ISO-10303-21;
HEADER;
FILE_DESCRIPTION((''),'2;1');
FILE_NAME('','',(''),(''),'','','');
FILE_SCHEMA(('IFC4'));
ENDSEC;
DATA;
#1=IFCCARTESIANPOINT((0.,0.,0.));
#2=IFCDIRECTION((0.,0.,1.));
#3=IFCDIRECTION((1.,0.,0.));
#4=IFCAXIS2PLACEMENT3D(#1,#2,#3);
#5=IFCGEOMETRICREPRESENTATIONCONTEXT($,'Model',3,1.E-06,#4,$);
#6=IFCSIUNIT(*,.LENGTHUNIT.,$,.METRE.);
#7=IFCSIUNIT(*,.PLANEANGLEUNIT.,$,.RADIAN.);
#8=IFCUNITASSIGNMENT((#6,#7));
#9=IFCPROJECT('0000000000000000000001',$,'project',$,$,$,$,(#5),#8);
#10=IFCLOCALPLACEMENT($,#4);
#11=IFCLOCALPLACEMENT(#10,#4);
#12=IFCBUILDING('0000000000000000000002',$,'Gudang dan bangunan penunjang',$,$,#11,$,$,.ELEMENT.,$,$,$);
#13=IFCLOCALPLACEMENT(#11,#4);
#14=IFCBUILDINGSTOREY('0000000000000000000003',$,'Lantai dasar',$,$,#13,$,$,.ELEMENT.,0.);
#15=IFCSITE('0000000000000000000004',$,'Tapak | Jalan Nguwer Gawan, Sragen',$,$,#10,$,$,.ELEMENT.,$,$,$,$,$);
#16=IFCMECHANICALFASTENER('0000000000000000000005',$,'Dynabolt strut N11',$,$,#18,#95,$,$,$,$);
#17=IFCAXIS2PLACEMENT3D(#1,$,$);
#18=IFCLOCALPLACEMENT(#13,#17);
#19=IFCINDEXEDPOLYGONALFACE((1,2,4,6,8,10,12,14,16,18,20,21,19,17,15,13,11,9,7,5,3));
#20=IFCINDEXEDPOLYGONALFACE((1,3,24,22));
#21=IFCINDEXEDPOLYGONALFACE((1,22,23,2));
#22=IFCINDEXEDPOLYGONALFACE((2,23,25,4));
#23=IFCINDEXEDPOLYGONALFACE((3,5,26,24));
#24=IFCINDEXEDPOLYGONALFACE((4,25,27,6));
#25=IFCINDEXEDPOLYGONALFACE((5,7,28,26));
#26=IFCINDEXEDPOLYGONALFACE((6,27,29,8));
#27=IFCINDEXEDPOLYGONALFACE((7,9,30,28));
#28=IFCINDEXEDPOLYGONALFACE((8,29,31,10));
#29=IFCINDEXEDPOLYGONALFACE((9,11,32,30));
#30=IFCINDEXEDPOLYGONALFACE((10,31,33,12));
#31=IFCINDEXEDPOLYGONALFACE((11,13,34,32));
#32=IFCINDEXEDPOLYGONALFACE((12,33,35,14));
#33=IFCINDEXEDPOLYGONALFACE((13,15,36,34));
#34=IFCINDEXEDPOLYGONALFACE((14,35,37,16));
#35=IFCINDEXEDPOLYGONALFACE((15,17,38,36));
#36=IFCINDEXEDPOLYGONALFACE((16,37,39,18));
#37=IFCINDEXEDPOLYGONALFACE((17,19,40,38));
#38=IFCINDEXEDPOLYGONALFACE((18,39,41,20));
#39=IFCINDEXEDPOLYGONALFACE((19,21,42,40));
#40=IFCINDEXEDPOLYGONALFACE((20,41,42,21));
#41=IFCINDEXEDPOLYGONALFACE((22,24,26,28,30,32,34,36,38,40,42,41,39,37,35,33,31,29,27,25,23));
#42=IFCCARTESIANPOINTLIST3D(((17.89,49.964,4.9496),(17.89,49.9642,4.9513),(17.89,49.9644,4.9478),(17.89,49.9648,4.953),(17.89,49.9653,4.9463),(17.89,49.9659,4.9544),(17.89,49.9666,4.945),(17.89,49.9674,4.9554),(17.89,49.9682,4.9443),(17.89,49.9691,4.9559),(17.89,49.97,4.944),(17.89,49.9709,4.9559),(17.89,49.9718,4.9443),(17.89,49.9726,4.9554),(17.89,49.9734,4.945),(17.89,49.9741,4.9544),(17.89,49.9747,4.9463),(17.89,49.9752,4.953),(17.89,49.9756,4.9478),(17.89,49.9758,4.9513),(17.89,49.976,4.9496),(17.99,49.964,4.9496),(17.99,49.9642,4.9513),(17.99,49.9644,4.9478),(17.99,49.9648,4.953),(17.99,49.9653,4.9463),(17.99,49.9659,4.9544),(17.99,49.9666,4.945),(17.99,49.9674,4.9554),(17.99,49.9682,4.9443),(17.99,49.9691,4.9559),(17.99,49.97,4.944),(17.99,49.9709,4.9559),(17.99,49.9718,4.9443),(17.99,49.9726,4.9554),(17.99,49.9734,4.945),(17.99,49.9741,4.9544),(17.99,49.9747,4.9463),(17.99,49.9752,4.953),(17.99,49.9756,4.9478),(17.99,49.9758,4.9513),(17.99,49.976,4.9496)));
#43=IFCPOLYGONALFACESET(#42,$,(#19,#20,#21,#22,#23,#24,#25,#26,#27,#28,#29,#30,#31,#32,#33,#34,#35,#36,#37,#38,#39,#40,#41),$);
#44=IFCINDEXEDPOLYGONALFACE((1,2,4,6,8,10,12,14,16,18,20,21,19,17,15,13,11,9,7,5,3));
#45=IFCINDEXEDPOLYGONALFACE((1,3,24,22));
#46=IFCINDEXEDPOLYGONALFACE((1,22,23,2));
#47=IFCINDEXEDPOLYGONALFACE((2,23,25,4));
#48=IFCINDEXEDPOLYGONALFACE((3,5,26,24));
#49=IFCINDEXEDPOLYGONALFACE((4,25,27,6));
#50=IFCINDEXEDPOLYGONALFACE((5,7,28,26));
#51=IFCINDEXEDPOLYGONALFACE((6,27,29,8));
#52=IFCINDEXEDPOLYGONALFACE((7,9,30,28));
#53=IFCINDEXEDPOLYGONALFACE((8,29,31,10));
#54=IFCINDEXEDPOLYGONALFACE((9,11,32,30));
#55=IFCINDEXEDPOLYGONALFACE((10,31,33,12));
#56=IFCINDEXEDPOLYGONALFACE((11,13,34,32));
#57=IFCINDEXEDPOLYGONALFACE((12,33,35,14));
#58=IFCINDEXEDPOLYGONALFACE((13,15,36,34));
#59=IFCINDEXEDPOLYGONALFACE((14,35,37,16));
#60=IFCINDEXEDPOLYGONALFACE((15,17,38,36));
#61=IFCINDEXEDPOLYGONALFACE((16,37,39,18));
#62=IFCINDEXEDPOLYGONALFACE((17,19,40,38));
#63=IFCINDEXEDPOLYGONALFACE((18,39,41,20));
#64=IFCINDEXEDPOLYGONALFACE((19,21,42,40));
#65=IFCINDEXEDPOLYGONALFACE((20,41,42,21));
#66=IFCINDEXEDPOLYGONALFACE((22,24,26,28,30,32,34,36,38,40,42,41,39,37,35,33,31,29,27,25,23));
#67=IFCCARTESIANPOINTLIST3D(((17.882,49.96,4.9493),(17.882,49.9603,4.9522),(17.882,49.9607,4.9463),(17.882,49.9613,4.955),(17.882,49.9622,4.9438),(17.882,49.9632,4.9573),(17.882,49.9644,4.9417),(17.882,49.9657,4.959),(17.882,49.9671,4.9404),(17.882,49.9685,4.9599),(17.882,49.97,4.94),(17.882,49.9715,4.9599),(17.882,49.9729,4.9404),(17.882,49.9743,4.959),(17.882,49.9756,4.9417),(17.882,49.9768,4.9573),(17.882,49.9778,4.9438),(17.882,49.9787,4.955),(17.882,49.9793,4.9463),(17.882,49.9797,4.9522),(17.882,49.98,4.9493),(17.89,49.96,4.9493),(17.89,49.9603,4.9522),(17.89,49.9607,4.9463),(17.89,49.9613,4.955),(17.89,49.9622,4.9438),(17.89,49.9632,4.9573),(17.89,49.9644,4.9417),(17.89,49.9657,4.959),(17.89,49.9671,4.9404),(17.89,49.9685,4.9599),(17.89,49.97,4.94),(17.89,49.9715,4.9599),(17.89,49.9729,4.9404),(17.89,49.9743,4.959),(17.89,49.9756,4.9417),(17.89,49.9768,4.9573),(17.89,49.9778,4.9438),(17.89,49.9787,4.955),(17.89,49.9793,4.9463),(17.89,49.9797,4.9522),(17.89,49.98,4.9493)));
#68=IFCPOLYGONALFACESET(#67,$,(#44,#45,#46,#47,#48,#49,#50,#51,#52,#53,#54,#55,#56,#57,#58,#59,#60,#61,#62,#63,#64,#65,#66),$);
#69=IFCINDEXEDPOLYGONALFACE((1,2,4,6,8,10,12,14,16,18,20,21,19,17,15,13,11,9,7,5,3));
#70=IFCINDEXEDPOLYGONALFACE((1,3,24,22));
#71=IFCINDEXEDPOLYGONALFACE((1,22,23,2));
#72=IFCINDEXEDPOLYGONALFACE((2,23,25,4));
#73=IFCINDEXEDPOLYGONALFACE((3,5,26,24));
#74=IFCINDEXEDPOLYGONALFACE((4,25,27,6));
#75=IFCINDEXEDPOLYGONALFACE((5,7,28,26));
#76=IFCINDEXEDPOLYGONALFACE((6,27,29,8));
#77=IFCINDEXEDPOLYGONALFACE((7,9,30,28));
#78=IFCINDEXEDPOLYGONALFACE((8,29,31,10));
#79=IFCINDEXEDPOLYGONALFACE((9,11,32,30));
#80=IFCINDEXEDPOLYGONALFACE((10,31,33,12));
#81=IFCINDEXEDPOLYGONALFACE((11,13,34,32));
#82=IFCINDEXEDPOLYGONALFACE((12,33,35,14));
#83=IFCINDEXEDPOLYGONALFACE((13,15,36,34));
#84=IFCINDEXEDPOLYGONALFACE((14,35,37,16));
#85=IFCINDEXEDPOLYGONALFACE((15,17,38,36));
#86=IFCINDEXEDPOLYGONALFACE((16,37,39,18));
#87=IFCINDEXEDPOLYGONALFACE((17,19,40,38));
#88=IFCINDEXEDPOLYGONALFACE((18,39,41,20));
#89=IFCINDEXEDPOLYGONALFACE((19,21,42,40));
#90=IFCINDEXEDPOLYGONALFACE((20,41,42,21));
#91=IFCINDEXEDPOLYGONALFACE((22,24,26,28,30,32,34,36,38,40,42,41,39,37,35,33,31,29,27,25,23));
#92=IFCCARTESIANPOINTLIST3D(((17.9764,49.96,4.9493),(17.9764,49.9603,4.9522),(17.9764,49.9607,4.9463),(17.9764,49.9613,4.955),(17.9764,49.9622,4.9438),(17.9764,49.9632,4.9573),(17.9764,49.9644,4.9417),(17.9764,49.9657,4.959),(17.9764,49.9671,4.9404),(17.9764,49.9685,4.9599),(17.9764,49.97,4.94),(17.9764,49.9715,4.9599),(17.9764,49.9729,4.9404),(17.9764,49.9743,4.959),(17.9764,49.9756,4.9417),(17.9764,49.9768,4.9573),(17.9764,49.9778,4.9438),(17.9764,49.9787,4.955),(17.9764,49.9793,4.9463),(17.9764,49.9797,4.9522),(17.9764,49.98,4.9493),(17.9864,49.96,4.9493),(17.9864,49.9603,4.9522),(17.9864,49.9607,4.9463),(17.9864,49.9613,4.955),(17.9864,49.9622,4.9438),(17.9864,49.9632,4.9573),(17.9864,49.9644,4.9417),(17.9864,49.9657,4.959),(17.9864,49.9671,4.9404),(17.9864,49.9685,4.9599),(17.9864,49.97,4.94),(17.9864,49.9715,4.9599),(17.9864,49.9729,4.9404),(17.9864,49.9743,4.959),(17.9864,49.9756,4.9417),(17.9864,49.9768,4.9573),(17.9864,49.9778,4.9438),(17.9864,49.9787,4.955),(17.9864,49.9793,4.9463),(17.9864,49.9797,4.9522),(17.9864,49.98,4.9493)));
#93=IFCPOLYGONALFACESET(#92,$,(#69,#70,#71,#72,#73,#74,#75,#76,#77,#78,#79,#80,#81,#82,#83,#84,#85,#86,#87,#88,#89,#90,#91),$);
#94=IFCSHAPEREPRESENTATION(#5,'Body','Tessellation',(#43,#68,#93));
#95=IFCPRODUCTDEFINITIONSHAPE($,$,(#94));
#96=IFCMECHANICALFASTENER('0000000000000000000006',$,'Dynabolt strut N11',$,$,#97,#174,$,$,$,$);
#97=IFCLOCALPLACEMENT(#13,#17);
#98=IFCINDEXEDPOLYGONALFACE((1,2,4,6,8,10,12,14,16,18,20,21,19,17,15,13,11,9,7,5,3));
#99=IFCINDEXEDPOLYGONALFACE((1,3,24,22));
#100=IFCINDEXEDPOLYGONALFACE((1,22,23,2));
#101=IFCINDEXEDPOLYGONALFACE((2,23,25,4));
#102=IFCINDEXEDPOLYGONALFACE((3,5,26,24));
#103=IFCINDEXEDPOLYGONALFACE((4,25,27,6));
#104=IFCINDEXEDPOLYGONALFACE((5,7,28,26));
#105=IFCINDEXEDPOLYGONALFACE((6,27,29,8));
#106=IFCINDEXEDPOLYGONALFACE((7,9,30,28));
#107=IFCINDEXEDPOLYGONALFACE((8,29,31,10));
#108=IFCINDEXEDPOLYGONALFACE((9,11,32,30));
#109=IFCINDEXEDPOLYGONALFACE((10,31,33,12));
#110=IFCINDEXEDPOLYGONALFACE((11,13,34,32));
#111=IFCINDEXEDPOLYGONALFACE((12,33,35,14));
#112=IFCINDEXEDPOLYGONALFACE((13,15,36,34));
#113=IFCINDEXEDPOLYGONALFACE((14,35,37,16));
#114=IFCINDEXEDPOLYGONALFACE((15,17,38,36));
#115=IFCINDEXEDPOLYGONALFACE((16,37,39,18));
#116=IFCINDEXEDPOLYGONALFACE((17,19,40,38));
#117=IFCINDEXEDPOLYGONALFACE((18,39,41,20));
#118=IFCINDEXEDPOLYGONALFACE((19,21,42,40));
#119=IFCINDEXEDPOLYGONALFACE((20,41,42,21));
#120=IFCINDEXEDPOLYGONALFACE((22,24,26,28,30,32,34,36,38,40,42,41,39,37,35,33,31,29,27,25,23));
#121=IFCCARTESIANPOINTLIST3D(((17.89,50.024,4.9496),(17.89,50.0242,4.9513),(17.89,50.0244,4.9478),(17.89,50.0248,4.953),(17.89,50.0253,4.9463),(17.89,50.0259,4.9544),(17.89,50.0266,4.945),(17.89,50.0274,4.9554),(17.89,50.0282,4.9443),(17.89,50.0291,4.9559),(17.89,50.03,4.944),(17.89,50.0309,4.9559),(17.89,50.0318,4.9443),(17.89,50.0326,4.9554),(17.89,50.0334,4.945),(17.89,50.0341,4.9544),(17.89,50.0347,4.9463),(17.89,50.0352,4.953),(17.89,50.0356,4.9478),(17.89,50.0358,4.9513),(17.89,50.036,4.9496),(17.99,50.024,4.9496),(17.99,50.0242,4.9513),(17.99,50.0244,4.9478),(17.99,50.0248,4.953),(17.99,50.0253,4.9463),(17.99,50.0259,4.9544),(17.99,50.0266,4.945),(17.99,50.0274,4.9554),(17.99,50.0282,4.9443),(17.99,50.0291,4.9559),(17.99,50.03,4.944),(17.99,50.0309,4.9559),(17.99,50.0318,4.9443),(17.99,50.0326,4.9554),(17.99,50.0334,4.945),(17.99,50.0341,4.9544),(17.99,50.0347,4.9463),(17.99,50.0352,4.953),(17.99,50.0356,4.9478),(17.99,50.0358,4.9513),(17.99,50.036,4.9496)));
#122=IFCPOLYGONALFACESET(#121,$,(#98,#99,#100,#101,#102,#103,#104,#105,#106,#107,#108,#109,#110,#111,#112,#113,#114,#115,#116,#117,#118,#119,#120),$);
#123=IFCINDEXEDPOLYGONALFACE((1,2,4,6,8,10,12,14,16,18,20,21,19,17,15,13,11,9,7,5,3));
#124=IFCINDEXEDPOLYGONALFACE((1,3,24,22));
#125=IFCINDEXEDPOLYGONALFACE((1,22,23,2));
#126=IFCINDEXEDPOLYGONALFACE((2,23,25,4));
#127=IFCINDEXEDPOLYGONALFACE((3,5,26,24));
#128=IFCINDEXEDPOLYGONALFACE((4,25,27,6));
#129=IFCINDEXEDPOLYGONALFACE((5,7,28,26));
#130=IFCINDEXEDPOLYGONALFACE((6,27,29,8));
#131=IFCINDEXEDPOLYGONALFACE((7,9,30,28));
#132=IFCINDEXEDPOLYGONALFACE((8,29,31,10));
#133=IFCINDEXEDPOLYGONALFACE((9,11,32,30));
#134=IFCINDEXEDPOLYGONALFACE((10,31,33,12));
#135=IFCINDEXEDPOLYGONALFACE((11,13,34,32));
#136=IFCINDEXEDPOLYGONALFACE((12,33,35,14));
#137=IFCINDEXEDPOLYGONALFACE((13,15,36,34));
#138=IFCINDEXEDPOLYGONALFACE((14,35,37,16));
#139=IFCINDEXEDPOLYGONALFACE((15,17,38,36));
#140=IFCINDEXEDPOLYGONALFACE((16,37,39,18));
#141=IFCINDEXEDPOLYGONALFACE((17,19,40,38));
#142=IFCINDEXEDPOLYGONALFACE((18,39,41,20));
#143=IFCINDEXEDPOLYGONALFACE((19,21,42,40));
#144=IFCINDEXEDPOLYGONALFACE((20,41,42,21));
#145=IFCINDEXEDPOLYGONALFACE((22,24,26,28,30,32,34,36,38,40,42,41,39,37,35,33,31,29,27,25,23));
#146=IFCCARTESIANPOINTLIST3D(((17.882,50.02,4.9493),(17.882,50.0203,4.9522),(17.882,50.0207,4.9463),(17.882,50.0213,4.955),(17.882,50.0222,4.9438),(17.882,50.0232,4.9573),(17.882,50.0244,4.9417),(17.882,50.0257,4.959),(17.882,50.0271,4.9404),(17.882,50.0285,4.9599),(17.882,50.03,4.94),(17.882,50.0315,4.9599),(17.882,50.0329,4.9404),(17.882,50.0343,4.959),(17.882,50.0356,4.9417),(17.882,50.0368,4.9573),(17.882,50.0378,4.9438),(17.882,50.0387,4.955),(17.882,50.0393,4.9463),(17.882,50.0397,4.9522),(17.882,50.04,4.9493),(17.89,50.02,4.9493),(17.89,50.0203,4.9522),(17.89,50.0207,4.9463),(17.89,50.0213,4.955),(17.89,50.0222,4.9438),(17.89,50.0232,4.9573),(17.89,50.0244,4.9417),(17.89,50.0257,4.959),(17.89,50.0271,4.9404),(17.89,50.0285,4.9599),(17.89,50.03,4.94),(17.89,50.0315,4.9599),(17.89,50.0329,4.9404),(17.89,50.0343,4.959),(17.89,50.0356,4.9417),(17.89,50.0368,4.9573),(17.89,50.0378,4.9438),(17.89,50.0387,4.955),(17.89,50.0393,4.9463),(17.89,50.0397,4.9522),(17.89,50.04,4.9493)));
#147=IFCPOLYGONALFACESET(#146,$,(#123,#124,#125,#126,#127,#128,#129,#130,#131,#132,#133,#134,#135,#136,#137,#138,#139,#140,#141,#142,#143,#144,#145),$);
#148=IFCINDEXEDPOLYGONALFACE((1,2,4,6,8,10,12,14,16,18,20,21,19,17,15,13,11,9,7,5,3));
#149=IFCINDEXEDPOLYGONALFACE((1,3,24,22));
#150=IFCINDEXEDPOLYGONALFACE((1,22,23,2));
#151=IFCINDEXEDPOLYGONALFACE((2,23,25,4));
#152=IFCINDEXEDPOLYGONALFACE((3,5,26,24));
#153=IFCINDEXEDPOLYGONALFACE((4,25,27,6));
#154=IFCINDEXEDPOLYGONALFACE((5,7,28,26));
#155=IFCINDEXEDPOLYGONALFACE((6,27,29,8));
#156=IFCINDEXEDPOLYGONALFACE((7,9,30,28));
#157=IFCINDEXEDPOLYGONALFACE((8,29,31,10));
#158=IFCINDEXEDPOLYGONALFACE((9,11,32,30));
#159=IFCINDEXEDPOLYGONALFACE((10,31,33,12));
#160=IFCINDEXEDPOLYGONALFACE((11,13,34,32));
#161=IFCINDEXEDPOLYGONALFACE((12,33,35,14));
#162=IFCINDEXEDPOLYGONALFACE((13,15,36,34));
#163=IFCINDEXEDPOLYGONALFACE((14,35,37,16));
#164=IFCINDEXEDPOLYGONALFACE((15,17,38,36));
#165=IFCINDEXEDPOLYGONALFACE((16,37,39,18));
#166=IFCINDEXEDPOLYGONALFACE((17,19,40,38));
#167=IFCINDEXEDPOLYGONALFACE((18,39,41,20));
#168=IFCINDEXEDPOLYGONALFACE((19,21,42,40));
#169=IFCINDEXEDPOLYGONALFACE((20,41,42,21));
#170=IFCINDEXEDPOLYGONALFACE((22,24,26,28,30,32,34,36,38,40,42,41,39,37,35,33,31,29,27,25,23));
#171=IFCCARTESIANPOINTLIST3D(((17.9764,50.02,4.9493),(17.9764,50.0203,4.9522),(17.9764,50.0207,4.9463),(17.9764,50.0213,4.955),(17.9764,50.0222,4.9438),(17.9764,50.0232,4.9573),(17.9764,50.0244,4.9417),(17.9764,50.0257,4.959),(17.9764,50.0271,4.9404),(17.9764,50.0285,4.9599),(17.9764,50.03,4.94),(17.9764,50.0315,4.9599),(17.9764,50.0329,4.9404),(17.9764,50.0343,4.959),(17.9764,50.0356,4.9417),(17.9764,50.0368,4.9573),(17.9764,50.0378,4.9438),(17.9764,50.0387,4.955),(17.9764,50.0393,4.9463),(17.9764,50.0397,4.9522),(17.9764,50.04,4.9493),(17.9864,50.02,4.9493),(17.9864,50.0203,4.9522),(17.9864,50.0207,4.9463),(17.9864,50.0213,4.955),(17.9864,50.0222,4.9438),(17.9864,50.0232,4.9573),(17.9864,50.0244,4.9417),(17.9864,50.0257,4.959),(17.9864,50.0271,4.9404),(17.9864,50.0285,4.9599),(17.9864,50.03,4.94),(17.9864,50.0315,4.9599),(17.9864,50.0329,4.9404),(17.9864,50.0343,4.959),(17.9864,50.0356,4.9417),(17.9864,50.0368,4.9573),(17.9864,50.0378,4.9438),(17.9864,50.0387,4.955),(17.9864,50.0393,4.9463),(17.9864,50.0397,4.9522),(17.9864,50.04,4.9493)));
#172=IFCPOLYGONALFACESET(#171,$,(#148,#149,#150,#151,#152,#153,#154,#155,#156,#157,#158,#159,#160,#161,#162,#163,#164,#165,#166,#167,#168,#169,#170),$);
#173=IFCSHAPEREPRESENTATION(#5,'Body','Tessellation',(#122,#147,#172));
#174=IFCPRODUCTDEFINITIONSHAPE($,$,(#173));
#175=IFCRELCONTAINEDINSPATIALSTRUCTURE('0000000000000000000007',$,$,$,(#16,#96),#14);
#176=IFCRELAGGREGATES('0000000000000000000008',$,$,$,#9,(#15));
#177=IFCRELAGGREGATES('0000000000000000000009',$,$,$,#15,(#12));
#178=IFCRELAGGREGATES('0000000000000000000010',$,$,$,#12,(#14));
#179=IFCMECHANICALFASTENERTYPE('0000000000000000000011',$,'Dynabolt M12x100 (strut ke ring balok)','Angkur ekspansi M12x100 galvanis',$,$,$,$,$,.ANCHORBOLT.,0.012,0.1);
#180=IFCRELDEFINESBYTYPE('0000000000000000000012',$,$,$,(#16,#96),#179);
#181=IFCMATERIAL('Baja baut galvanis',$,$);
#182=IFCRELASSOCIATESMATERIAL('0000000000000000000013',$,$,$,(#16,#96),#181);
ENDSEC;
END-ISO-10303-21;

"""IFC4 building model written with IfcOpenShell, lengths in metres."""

from ifc_helpers import new_model, si_unit, frame, origin_with_axes, place, context, project, spatial, circle, extrude, source, transform, mapped, material, type_object, type_shapes, element, save


model = new_model("IFC4")

# Units and contexts
model_context = context("Model", 3, precision=1e-06, world=origin_with_axes())
ifc_project = project(units=[si_unit("LENGTHUNIT", "METRE"), si_unit("PLANEANGLEUNIT", "RADIAN")], contexts=[model_context])

# Site, building, storey
site_placement = place(None, origin_with_axes())
site = spatial("IfcSite", under=ifc_project, at=site_placement, Name="Tapak | Jalan Nguwer Gawan, Sragen", CompositionType="ELEMENT")
building_placement = place(site_placement, origin_with_axes())
building = spatial("IfcBuilding", under=site, at=building_placement, Name="Gudang dan bangunan penunjang", CompositionType="ELEMENT")
storey_placement = place(building_placement, origin_with_axes())
storey = spatial("IfcBuildingStorey", under=building, at=storey_placement, Name="Lantai dasar", CompositionType="ELEMENT", Elevation=0.0)

# Mechanical fasteners
ifc_material = material(Name="Baja baut galvanis")
mechanical_fastener_type = type_object("IfcMechanicalFastenerType", Name="Dynabolt M12x100 (strut ke ring balok)", Description="Angkur ekspansi M12x100 galvanis", NominalDiameter=0.012, NominalLength=0.1, PredefinedType="ANCHORBOLT")
shared_shape = source(origin_with_axes(), model_context, "Body", "SweptSolid", [
    extrude(circle(Radius=0.006), origin_with_axes(), (0.0, 0.0, 1.0), 0.1),
    extrude(circle(Radius=0.01), frame((0.0, 0.0, -0.008), z_axis=(0.0, 0.0, 1.0), x_axis=(1.0, 0.0, 0.0)), (0.0, 0.0, 1.0), 0.008),
    extrude(circle(Radius=0.01), frame((0.0, 0.0, 0.0864), z_axis=(0.0, 0.0, 1.0), x_axis=(1.0, 0.0, 0.0)), (0.0, 0.0, 1.0), 0.01),
])
type_shapes(mechanical_fastener_type, [shared_shape])
placement = place(None, origin_with_axes())
element("IfcMechanicalFastener", 1, at=placement, inside=storey, type_object=mechanical_fastener_type, material=ifc_material, Name="Dynabolt strut N11", context=model_context, shape_type="MappedRepresentation", body=[
    mapped(shared_shape, transform((17.89, 49.97, 4.95), x_axis=(0.0, 0.0, -1.0), y_axis=(0.0, 1.0, 0.0), z_axis=(1.0, 0.0, 0.0), scale=1.0)),
])
element("IfcMechanicalFastener", 2, at=placement, inside=storey, type_object=mechanical_fastener_type, material=ifc_material, Name="Dynabolt strut N11", context=model_context, shape_type="MappedRepresentation", body=[
    mapped(shared_shape, transform((17.89, 50.03, 4.95), x_axis=(0.0, 0.0, -1.0), y_axis=(0.0, 1.0, 0.0), z_axis=(1.0, 0.0, 0.0), scale=1.0)),
])

save(model, "model.ifc")
